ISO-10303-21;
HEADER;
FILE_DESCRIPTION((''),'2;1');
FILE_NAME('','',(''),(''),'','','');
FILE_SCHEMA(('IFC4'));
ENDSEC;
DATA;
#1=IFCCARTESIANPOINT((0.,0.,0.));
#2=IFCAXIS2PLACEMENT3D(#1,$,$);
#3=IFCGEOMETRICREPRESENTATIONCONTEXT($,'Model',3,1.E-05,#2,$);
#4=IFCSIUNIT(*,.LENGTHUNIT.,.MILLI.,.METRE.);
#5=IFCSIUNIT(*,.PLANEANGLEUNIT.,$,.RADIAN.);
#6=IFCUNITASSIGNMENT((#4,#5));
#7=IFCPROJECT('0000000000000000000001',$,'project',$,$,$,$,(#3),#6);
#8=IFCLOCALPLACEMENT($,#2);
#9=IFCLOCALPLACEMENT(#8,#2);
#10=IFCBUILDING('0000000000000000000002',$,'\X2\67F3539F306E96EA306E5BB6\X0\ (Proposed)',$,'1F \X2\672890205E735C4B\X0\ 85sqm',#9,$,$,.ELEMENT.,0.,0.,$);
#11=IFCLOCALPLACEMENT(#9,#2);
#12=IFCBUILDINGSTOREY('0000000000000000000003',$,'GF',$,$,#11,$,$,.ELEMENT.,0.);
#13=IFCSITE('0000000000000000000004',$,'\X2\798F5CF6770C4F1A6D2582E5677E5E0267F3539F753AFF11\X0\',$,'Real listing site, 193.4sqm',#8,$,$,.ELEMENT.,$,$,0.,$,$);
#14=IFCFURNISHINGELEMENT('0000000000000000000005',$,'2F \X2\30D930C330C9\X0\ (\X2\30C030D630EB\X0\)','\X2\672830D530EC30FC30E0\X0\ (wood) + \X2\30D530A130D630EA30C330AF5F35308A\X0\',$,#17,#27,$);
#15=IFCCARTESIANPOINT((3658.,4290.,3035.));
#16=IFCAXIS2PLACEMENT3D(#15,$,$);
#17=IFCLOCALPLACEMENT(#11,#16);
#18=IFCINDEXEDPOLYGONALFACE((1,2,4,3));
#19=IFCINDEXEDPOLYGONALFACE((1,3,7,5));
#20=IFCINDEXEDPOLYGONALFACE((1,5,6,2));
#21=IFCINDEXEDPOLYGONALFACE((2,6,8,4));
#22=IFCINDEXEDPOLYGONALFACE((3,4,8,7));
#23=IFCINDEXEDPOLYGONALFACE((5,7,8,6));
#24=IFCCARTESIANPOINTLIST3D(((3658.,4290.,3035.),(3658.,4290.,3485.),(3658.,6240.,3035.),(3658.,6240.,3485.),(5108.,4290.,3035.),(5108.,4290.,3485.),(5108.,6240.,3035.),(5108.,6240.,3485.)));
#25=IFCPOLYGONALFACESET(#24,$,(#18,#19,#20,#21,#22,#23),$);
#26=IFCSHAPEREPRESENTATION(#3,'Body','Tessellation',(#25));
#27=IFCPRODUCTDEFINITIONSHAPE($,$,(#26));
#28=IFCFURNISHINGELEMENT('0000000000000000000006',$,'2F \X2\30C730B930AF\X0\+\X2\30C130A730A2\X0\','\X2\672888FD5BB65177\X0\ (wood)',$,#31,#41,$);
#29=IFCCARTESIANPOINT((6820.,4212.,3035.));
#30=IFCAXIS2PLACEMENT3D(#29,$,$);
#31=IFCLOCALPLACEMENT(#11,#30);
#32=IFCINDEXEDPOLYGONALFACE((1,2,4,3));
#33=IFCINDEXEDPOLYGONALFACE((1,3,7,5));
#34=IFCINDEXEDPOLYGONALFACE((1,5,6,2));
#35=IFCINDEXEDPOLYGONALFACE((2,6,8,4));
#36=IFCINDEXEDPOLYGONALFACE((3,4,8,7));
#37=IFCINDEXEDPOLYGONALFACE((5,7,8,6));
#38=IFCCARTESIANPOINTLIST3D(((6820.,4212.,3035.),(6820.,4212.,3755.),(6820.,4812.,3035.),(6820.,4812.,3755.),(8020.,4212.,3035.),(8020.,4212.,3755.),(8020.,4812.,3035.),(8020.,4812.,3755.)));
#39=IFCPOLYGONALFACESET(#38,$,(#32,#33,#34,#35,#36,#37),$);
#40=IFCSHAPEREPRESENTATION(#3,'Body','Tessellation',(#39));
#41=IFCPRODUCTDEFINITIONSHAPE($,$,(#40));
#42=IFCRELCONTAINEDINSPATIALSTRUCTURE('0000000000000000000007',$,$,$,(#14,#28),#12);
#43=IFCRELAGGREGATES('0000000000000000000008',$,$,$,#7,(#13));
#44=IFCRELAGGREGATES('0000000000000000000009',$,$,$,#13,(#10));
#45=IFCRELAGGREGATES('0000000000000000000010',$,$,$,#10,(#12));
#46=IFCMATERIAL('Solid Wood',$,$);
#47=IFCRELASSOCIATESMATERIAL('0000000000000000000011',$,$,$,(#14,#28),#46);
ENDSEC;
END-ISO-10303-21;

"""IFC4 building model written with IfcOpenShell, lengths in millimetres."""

from ifc_helpers import new_model, si_unit, frame, frame_2d, origin, place, context, project, spatial, rectangle, extrude, material, element, save


model = new_model("IFC4")

# Units and contexts
model_context = context("Model", 3, precision=1e-05, world=origin())
ifc_project = project(units=[si_unit("LENGTHUNIT", "METRE", prefix="MILLI"), si_unit("PLANEANGLEUNIT", "RADIAN")], contexts=[model_context])

# Site, building, storey
site_placement = place(None, origin())
site = spatial("IfcSite", under=ifc_project, at=site_placement, Name="福島県会津若松市柳原町１", ObjectType="Real listing site, 193.4sqm", CompositionType="ELEMENT", RefElevation=0.0)
building_placement = place(site_placement, origin())
building = spatial("IfcBuilding", under=site, at=building_placement, Name="柳原の雪の家 (Proposed)", ObjectType="1F 木造平屋 85sqm", CompositionType="ELEMENT", ElevationOfRefHeight=0.0, ElevationOfTerrain=0.0)
storey_placement = place(building_placement, origin())
storey = spatial("IfcBuildingStorey", under=building, at=storey_placement, Name="GF", CompositionType="ELEMENT", Elevation=0.0)

# Shared definitions
ifc_material_1 = material(Name="Solid Wood")

# Furnishing elements
furnishing_1_placement = place(storey_placement, frame((3658.0, 4290.0, 3035.0)))
element("IfcFurnishingElement", 1, at=furnishing_1_placement, inside=storey, material=ifc_material_1, Name="2F ベッド (ダブル)", Description="木フレーム (wood) + ファブリック張り", context=model_context, shape_type="SweptSolid", body=[
    extrude(rectangle(XDim=1450.0, YDim=1950.0, at=frame_2d((725.0, 975.0))), frame((3658.0, 4290.0, 3035.0)), (0.0, 0.0, 1.0), 450.0),
])
furnishing_2_placement = place(storey_placement, frame((6820.0, 4212.0, 3035.0)))
element("IfcFurnishingElement", 2, at=furnishing_2_placement, inside=storey, material=ifc_material_1, Name="2F デスク+チェア", Description="木製家具 (wood)", context=model_context, shape_type="SweptSolid", body=[
    extrude(rectangle(XDim=1200.0, YDim=600.0, at=frame_2d((600.0, 300.0))), frame((6820.0, 4212.0, 3035.0)), (0.0, 0.0, 1.0), 720.0),
])

save(model, "model.ifc")
